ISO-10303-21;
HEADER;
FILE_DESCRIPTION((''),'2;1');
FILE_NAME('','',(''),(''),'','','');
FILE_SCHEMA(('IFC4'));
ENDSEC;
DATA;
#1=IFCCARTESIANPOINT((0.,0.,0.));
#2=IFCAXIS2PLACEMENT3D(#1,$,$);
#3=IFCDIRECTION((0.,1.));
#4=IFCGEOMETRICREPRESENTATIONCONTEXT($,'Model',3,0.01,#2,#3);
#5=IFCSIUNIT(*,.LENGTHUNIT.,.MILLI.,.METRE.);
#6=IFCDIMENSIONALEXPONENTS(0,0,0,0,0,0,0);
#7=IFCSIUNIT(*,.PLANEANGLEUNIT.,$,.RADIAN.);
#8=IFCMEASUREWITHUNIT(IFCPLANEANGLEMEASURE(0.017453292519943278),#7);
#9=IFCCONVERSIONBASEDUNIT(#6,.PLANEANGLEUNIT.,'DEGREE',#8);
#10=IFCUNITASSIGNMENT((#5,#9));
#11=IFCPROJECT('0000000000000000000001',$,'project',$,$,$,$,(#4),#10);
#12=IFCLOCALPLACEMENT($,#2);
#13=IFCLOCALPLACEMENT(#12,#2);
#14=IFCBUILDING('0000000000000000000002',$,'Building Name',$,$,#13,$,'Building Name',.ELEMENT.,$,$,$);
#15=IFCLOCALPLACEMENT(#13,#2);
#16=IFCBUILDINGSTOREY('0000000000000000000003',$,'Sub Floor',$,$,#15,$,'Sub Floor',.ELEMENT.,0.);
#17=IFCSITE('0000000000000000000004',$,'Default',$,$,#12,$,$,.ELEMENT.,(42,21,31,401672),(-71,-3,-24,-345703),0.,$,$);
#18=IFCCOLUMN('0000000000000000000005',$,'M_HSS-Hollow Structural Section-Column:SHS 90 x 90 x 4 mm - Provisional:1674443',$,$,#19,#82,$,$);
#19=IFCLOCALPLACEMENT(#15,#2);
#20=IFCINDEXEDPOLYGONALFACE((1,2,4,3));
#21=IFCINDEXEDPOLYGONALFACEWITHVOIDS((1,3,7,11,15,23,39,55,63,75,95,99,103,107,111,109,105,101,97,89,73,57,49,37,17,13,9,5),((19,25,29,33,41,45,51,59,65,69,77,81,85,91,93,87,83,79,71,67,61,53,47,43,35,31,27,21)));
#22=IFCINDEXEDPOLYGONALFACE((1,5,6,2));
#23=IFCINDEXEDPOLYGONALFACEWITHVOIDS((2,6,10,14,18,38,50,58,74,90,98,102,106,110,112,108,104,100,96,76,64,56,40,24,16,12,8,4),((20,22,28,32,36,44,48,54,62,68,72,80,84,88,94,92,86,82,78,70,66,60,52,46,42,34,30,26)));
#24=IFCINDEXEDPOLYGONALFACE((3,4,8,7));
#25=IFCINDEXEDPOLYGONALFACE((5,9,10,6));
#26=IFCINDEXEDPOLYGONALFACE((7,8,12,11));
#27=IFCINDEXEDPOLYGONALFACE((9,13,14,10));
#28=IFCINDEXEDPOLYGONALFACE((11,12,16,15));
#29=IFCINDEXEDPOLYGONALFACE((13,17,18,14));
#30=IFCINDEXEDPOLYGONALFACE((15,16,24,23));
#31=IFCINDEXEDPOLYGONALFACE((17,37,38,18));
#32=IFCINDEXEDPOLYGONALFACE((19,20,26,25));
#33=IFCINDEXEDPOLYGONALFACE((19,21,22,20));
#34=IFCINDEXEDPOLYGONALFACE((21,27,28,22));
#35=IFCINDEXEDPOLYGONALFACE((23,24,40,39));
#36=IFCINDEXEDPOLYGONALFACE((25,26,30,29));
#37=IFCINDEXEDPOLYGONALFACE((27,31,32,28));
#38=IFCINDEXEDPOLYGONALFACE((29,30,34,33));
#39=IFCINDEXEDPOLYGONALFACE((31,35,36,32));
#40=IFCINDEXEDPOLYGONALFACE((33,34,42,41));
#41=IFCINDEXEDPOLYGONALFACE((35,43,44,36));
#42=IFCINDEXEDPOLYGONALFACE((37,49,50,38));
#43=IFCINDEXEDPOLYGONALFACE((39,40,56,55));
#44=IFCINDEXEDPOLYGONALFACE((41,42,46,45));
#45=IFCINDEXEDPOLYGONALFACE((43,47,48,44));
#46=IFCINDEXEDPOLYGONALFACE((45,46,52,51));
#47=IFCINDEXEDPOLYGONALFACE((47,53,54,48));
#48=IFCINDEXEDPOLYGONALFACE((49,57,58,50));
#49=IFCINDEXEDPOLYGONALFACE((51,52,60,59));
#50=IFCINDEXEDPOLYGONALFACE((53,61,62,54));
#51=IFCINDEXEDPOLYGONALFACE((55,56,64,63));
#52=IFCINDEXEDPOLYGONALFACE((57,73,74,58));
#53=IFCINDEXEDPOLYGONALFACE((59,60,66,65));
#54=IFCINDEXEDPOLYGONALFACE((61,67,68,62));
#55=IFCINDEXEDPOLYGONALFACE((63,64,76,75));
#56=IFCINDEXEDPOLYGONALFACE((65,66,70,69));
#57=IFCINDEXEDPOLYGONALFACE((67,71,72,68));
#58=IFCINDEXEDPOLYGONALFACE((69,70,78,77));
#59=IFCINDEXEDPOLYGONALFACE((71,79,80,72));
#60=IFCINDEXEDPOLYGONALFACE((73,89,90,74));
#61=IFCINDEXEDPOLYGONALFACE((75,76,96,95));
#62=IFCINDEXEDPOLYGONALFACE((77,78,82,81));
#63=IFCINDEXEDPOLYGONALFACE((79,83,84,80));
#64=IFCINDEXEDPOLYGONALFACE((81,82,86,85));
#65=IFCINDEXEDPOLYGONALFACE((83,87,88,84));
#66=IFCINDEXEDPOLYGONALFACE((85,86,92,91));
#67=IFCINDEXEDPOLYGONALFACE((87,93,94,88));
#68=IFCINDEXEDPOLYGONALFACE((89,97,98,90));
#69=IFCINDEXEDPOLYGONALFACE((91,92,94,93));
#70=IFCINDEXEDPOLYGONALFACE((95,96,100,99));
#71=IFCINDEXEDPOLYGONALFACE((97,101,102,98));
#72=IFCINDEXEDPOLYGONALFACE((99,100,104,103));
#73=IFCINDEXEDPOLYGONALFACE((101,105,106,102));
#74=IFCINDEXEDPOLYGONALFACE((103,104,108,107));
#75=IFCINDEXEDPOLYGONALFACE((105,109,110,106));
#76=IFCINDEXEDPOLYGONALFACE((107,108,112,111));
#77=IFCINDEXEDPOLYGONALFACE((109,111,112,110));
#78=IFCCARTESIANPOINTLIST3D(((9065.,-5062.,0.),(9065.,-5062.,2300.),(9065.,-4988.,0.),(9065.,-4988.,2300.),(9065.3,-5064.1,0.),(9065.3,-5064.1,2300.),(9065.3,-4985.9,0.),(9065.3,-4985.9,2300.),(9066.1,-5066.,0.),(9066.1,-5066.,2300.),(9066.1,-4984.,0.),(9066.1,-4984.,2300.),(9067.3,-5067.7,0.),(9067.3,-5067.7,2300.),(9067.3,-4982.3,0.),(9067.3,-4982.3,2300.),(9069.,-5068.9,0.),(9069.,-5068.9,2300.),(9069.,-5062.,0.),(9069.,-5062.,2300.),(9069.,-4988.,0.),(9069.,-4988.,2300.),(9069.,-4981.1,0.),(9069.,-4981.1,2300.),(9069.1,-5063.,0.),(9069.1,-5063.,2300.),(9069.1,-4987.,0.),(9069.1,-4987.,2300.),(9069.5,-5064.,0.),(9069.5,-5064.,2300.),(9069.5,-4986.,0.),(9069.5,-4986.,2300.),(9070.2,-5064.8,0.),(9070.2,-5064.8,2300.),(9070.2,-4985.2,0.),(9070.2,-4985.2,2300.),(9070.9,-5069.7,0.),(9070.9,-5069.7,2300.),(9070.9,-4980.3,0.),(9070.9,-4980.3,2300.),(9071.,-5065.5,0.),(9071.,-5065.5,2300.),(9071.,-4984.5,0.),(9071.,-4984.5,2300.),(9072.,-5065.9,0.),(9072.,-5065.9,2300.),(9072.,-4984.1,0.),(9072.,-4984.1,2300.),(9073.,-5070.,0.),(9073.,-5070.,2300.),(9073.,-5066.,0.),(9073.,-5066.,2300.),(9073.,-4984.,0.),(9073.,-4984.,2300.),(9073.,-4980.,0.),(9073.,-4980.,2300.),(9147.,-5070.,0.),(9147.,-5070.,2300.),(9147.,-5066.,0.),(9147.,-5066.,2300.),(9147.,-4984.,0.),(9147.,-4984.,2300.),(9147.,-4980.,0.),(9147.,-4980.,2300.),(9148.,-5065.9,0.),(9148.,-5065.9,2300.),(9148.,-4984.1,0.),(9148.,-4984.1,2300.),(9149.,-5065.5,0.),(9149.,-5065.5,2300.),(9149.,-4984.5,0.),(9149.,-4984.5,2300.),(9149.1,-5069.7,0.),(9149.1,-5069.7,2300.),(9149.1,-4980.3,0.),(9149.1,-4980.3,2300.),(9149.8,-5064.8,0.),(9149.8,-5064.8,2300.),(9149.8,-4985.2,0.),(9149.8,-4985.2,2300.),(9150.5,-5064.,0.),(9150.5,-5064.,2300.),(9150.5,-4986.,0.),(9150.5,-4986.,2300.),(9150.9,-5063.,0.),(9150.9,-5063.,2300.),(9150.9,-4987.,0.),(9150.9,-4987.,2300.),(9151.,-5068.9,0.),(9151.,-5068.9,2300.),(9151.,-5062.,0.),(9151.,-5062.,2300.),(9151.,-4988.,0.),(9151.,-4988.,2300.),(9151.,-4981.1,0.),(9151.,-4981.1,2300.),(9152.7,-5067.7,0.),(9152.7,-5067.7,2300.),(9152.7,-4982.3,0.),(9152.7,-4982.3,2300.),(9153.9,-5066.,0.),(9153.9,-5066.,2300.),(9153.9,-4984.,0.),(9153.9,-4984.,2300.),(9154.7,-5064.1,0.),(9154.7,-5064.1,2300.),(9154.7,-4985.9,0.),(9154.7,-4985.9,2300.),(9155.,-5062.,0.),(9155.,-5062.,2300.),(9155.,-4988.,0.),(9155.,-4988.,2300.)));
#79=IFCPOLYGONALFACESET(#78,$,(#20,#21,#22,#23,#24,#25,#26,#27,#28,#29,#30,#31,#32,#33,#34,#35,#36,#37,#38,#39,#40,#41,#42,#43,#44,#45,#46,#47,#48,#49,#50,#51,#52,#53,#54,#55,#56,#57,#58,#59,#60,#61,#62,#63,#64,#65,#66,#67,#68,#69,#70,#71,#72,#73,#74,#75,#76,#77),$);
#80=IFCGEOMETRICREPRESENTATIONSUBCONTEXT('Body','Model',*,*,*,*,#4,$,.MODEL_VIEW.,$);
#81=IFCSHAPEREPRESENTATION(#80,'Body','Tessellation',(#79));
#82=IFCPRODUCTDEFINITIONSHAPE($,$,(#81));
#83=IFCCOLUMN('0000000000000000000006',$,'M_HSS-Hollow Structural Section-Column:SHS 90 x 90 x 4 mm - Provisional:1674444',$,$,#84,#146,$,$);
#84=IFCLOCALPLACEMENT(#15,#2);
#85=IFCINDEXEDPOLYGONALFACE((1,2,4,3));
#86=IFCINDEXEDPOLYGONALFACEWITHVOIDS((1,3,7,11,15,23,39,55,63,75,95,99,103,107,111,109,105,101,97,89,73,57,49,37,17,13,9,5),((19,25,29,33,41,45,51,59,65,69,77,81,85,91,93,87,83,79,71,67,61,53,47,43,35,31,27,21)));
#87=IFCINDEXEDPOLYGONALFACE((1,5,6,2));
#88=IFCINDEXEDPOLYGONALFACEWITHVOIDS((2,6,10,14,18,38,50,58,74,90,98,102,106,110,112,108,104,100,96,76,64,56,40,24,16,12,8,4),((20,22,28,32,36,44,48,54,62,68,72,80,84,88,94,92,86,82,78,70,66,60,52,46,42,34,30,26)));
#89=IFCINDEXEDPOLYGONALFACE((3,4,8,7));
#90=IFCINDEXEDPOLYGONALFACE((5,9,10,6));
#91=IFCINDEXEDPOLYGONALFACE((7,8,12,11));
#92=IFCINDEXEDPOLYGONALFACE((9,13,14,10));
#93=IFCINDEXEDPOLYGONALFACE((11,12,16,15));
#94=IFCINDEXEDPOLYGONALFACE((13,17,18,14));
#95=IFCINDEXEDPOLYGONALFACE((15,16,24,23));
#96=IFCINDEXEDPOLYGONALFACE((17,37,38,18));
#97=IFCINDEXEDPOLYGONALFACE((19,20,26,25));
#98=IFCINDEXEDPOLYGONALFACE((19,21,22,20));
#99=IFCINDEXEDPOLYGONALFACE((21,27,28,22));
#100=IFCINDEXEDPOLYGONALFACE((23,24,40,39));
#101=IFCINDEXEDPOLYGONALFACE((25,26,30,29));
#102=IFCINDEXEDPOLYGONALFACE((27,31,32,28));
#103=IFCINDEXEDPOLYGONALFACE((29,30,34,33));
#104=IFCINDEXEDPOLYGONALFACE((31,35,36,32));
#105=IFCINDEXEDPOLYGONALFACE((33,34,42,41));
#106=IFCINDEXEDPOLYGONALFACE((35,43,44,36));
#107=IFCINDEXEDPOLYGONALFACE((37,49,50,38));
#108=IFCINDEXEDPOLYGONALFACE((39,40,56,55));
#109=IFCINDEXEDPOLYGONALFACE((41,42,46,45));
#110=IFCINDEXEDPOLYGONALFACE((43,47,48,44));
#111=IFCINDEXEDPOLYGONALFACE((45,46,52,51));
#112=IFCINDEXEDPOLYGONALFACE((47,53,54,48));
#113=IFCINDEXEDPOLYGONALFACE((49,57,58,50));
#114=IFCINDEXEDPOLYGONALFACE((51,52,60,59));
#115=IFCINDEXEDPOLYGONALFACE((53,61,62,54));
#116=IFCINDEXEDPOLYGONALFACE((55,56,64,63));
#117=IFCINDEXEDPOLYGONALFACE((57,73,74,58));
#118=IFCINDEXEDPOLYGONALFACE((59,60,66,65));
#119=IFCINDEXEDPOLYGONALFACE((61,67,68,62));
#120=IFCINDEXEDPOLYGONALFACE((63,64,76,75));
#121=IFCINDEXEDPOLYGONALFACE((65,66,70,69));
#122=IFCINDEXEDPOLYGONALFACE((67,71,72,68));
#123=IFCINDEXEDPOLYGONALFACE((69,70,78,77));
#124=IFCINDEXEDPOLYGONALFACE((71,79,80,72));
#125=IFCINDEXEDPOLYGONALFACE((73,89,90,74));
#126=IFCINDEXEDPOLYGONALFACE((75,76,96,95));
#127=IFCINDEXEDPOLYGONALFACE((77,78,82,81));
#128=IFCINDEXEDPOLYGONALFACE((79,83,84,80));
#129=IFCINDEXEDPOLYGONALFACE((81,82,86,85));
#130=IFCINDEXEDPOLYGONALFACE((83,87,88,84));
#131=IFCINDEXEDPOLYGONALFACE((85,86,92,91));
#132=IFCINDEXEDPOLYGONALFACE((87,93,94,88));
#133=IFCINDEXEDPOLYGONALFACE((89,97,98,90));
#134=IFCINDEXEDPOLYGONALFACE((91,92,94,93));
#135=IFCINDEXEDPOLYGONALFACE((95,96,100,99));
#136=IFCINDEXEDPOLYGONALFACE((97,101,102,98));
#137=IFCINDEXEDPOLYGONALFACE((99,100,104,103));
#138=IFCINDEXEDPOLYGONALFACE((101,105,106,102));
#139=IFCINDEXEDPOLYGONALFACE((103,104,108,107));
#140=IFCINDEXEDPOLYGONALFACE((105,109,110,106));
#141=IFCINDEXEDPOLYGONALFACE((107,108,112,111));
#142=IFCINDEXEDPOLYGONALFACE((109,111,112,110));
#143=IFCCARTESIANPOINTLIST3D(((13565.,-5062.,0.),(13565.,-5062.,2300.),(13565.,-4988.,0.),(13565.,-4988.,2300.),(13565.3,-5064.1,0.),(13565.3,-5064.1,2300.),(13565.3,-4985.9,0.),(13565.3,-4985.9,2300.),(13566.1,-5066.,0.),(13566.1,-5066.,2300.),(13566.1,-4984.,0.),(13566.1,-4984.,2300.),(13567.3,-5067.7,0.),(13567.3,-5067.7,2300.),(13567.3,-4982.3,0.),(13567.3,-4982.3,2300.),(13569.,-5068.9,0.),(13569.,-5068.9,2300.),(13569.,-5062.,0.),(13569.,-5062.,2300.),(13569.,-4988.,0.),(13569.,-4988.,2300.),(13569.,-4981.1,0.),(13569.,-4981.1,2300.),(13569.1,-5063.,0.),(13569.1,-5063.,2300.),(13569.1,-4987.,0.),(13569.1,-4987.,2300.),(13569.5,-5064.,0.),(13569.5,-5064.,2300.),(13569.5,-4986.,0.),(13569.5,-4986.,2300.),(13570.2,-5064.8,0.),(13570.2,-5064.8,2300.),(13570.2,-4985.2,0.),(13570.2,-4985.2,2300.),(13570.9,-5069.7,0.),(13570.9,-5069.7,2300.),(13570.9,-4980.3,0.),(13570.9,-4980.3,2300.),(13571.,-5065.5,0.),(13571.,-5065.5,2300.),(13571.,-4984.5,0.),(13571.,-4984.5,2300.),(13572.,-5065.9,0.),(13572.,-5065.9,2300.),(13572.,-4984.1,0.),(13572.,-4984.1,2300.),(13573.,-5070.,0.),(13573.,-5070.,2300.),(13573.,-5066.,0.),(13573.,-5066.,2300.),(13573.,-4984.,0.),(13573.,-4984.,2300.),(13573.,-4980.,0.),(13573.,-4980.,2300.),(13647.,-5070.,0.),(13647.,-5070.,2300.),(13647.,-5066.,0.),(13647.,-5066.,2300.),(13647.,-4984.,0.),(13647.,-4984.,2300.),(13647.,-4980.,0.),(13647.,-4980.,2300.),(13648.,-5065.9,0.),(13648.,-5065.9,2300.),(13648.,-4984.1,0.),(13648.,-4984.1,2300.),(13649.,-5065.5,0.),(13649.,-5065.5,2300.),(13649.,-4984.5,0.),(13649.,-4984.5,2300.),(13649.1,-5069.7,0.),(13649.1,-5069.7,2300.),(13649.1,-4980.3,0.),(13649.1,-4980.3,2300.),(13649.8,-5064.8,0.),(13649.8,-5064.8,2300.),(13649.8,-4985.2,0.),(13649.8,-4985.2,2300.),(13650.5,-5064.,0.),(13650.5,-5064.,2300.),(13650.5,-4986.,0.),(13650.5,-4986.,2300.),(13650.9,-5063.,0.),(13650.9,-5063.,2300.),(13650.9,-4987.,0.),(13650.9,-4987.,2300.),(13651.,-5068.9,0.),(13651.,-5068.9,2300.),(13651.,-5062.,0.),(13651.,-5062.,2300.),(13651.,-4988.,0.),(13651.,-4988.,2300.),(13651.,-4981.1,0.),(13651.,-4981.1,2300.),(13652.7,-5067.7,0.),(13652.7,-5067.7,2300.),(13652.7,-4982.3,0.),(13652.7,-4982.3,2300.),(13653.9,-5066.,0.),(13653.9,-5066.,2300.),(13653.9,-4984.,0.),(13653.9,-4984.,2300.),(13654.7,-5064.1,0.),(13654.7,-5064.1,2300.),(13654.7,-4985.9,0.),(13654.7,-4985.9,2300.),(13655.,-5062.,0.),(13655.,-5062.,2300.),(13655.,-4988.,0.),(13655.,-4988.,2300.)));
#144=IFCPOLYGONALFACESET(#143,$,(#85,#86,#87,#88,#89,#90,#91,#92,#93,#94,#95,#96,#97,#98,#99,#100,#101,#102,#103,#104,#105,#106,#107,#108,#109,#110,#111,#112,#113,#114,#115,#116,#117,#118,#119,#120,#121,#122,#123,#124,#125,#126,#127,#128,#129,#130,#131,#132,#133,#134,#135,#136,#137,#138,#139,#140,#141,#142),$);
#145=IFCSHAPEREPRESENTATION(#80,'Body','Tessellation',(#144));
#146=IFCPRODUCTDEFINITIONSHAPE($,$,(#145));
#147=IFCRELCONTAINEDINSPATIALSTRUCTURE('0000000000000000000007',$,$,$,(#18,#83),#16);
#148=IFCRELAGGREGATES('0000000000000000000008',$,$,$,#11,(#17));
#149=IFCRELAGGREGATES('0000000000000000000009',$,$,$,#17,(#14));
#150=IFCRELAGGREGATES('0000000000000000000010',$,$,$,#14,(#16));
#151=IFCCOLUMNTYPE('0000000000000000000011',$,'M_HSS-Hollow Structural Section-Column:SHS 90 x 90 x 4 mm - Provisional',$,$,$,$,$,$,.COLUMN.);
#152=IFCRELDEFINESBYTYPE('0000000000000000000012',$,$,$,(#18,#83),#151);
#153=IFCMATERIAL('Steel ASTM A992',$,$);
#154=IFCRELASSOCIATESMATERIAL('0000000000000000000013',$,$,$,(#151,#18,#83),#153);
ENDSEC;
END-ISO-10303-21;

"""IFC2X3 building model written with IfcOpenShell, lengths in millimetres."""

from ifc_helpers import new_model, entity, si_unit, converted_unit, direction, frame, frame_2d, origin, place, context, subcontext, project, spatial, polyline, circle_curve, parameter, trimmed, segment, composite_curve, outline, extrude, source, transform, mapped, material, type_object, type_shapes, element, save


model = new_model("IFC2X3")

# Units and contexts
model_context = context("Model", 3, precision=0.01, world=origin(), true_north=direction((0.0, 1.0)))
body_context = subcontext(model_context, "Body", "Model", "MODEL_VIEW")
ifc_project = project(units=[si_unit("LENGTHUNIT", "METRE", prefix="MILLI"), converted_unit("PLANEANGLEUNIT", "DEGREE", entity("IfcPlaneAngleMeasure", 0.017453292519943278), si_unit("PLANEANGLEUNIT", "RADIAN"), dimensions=[0, 0, 0, 0, 0, 0, 0])], contexts=[model_context])

# Site, building, storey
site_placement = place(None, origin())
site = spatial("IfcSite", under=ifc_project, at=site_placement, Name="Default", CompositionType="ELEMENT", RefLatitude=(42, 21, 31, 401672), RefLongitude=(-71, -3, -24, -345703), RefElevation=0.0)
building_placement = place(site_placement, origin())
building = spatial("IfcBuilding", under=site, at=building_placement, Name="Building Name", LongName="Building Name", CompositionType="ELEMENT")
storey_placement = place(building_placement, origin())
storey = spatial("IfcBuildingStorey", under=building, at=storey_placement, Name="Sub Floor", LongName="Sub Floor", CompositionType="ELEMENT", Elevation=0.0)

# Columns
ifc_material_1 = material(Name="Steel ASTM A992")
column_type = type_object("IfcColumnType", Name="M_HSS-Hollow Structural Section-Column:SHS 90 x 90 x 4 mm - Provisional", PredefinedType="COLUMN", material=ifc_material_1)
shared_shape_1 = source(origin(), body_context, "Body", "SweptSolid", [
    extrude(outline(composite_curve([segment(polyline([(-37.0, -45.0), (37.0, -45.0)]), True, "CONTINUOUS"), segment(trimmed(circle_curve(frame_2d((37.0, -37.0), x_axis=(-1.0, 0.0)), 8.0), [parameter(90.0)], [parameter(180.0)], True, "PARAMETER"), True, "CONTINUOUS"), segment(polyline([(45.0, -37.0), (45.0, 37.0)]), True, "CONTINUOUS"), segment(trimmed(circle_curve(frame_2d((37.0, 37.0), x_axis=(-1.0, 0.0)), 8.0), [parameter(180.0)], [parameter(270.0)], True, "PARAMETER"), True, "CONTINUOUS"), segment(polyline([(37.0, 45.0), (-37.0, 45.0)]), True, "CONTINUOUS"), segment(trimmed(circle_curve(frame_2d((-37.0, 37.0), x_axis=(-1.0, 0.0)), 8.0), [parameter(270.0)], [parameter(360.0)], True, "PARAMETER"), True, "CONTINUOUS"), segment(polyline([(-45.0, 37.0), (-45.0, -37.0)]), True, "CONTINUOUS"), segment(trimmed(circle_curve(frame_2d((-37.0, -37.0), x_axis=(-1.0, 0.0)), 8.0), [parameter(360.0)], [parameter(90.0)], True, "PARAMETER"), True, "CONTINUOUS")], self_intersect=False), holes=[composite_curve([segment(trimmed(circle_curve(frame_2d((-37.0, -37.0), x_axis=(-1.0, 0.0)), 4.0), [parameter(0.0)], [parameter(90.0)], True, "PARAMETER"), False, "CONTINUOUS"), segment(polyline([(-41.0, -37.0), (-41.0, 37.0)]), True, "CONTINUOUS"), segment(trimmed(circle_curve(frame_2d((-37.0, 37.0), x_axis=(-1.0, 0.0)), 4.0), [parameter(270.0)], [parameter(0.0)], True, "PARAMETER"), False, "CONTINUOUS"), segment(polyline([(-37.0, 41.0), (37.0, 41.0)]), True, "CONTINUOUS"), segment(trimmed(circle_curve(frame_2d((37.0, 37.0), x_axis=(-1.0, 0.0)), 4.0), [parameter(180.0)], [parameter(270.0)], True, "PARAMETER"), False, "CONTINUOUS"), segment(polyline([(41.0, 37.0), (41.0, -37.0)]), True, "CONTINUOUS"), segment(trimmed(circle_curve(frame_2d((37.0, -37.0), x_axis=(-1.0, 0.0)), 4.0), [parameter(90.0)], [parameter(180.0)], True, "PARAMETER"), False, "CONTINUOUS"), segment(polyline([(37.0, -41.0), (-37.0, -41.0)]), True, "CONTINUOUS")], self_intersect=False)]), frame((0.0, 0.0, 0.0), z_axis=(0.0, 0.0, 1.0), x_axis=(-1.0, 0.0, 0.0)), (0.0, 0.0, 1.0), 2300.0),
])
type_shapes(column_type, [shared_shape_1])
for number, where, name in (
    (1, (9110.0, -5025.0, 0.0), "M_HSS-Hollow Structural Section-Column:SHS 90 x 90 x 4 mm - Provisional:1674443"),
    (2, (13610.0, -5025.0, 0.0), "M_HSS-Hollow Structural Section-Column:SHS 90 x 90 x 4 mm - Provisional:1674444"),
):
    element("IfcColumn", number, at=place(storey_placement, frame(where)), inside=storey, type_object=column_type, material=ifc_material_1, Name=name, context=body_context, shape_type="MappedRepresentation", body=[
        mapped(shared_shape_1, transform((0.0, 0.0, 0.0), scale=1.0)),
    ])

save(model, "model.ifc")
